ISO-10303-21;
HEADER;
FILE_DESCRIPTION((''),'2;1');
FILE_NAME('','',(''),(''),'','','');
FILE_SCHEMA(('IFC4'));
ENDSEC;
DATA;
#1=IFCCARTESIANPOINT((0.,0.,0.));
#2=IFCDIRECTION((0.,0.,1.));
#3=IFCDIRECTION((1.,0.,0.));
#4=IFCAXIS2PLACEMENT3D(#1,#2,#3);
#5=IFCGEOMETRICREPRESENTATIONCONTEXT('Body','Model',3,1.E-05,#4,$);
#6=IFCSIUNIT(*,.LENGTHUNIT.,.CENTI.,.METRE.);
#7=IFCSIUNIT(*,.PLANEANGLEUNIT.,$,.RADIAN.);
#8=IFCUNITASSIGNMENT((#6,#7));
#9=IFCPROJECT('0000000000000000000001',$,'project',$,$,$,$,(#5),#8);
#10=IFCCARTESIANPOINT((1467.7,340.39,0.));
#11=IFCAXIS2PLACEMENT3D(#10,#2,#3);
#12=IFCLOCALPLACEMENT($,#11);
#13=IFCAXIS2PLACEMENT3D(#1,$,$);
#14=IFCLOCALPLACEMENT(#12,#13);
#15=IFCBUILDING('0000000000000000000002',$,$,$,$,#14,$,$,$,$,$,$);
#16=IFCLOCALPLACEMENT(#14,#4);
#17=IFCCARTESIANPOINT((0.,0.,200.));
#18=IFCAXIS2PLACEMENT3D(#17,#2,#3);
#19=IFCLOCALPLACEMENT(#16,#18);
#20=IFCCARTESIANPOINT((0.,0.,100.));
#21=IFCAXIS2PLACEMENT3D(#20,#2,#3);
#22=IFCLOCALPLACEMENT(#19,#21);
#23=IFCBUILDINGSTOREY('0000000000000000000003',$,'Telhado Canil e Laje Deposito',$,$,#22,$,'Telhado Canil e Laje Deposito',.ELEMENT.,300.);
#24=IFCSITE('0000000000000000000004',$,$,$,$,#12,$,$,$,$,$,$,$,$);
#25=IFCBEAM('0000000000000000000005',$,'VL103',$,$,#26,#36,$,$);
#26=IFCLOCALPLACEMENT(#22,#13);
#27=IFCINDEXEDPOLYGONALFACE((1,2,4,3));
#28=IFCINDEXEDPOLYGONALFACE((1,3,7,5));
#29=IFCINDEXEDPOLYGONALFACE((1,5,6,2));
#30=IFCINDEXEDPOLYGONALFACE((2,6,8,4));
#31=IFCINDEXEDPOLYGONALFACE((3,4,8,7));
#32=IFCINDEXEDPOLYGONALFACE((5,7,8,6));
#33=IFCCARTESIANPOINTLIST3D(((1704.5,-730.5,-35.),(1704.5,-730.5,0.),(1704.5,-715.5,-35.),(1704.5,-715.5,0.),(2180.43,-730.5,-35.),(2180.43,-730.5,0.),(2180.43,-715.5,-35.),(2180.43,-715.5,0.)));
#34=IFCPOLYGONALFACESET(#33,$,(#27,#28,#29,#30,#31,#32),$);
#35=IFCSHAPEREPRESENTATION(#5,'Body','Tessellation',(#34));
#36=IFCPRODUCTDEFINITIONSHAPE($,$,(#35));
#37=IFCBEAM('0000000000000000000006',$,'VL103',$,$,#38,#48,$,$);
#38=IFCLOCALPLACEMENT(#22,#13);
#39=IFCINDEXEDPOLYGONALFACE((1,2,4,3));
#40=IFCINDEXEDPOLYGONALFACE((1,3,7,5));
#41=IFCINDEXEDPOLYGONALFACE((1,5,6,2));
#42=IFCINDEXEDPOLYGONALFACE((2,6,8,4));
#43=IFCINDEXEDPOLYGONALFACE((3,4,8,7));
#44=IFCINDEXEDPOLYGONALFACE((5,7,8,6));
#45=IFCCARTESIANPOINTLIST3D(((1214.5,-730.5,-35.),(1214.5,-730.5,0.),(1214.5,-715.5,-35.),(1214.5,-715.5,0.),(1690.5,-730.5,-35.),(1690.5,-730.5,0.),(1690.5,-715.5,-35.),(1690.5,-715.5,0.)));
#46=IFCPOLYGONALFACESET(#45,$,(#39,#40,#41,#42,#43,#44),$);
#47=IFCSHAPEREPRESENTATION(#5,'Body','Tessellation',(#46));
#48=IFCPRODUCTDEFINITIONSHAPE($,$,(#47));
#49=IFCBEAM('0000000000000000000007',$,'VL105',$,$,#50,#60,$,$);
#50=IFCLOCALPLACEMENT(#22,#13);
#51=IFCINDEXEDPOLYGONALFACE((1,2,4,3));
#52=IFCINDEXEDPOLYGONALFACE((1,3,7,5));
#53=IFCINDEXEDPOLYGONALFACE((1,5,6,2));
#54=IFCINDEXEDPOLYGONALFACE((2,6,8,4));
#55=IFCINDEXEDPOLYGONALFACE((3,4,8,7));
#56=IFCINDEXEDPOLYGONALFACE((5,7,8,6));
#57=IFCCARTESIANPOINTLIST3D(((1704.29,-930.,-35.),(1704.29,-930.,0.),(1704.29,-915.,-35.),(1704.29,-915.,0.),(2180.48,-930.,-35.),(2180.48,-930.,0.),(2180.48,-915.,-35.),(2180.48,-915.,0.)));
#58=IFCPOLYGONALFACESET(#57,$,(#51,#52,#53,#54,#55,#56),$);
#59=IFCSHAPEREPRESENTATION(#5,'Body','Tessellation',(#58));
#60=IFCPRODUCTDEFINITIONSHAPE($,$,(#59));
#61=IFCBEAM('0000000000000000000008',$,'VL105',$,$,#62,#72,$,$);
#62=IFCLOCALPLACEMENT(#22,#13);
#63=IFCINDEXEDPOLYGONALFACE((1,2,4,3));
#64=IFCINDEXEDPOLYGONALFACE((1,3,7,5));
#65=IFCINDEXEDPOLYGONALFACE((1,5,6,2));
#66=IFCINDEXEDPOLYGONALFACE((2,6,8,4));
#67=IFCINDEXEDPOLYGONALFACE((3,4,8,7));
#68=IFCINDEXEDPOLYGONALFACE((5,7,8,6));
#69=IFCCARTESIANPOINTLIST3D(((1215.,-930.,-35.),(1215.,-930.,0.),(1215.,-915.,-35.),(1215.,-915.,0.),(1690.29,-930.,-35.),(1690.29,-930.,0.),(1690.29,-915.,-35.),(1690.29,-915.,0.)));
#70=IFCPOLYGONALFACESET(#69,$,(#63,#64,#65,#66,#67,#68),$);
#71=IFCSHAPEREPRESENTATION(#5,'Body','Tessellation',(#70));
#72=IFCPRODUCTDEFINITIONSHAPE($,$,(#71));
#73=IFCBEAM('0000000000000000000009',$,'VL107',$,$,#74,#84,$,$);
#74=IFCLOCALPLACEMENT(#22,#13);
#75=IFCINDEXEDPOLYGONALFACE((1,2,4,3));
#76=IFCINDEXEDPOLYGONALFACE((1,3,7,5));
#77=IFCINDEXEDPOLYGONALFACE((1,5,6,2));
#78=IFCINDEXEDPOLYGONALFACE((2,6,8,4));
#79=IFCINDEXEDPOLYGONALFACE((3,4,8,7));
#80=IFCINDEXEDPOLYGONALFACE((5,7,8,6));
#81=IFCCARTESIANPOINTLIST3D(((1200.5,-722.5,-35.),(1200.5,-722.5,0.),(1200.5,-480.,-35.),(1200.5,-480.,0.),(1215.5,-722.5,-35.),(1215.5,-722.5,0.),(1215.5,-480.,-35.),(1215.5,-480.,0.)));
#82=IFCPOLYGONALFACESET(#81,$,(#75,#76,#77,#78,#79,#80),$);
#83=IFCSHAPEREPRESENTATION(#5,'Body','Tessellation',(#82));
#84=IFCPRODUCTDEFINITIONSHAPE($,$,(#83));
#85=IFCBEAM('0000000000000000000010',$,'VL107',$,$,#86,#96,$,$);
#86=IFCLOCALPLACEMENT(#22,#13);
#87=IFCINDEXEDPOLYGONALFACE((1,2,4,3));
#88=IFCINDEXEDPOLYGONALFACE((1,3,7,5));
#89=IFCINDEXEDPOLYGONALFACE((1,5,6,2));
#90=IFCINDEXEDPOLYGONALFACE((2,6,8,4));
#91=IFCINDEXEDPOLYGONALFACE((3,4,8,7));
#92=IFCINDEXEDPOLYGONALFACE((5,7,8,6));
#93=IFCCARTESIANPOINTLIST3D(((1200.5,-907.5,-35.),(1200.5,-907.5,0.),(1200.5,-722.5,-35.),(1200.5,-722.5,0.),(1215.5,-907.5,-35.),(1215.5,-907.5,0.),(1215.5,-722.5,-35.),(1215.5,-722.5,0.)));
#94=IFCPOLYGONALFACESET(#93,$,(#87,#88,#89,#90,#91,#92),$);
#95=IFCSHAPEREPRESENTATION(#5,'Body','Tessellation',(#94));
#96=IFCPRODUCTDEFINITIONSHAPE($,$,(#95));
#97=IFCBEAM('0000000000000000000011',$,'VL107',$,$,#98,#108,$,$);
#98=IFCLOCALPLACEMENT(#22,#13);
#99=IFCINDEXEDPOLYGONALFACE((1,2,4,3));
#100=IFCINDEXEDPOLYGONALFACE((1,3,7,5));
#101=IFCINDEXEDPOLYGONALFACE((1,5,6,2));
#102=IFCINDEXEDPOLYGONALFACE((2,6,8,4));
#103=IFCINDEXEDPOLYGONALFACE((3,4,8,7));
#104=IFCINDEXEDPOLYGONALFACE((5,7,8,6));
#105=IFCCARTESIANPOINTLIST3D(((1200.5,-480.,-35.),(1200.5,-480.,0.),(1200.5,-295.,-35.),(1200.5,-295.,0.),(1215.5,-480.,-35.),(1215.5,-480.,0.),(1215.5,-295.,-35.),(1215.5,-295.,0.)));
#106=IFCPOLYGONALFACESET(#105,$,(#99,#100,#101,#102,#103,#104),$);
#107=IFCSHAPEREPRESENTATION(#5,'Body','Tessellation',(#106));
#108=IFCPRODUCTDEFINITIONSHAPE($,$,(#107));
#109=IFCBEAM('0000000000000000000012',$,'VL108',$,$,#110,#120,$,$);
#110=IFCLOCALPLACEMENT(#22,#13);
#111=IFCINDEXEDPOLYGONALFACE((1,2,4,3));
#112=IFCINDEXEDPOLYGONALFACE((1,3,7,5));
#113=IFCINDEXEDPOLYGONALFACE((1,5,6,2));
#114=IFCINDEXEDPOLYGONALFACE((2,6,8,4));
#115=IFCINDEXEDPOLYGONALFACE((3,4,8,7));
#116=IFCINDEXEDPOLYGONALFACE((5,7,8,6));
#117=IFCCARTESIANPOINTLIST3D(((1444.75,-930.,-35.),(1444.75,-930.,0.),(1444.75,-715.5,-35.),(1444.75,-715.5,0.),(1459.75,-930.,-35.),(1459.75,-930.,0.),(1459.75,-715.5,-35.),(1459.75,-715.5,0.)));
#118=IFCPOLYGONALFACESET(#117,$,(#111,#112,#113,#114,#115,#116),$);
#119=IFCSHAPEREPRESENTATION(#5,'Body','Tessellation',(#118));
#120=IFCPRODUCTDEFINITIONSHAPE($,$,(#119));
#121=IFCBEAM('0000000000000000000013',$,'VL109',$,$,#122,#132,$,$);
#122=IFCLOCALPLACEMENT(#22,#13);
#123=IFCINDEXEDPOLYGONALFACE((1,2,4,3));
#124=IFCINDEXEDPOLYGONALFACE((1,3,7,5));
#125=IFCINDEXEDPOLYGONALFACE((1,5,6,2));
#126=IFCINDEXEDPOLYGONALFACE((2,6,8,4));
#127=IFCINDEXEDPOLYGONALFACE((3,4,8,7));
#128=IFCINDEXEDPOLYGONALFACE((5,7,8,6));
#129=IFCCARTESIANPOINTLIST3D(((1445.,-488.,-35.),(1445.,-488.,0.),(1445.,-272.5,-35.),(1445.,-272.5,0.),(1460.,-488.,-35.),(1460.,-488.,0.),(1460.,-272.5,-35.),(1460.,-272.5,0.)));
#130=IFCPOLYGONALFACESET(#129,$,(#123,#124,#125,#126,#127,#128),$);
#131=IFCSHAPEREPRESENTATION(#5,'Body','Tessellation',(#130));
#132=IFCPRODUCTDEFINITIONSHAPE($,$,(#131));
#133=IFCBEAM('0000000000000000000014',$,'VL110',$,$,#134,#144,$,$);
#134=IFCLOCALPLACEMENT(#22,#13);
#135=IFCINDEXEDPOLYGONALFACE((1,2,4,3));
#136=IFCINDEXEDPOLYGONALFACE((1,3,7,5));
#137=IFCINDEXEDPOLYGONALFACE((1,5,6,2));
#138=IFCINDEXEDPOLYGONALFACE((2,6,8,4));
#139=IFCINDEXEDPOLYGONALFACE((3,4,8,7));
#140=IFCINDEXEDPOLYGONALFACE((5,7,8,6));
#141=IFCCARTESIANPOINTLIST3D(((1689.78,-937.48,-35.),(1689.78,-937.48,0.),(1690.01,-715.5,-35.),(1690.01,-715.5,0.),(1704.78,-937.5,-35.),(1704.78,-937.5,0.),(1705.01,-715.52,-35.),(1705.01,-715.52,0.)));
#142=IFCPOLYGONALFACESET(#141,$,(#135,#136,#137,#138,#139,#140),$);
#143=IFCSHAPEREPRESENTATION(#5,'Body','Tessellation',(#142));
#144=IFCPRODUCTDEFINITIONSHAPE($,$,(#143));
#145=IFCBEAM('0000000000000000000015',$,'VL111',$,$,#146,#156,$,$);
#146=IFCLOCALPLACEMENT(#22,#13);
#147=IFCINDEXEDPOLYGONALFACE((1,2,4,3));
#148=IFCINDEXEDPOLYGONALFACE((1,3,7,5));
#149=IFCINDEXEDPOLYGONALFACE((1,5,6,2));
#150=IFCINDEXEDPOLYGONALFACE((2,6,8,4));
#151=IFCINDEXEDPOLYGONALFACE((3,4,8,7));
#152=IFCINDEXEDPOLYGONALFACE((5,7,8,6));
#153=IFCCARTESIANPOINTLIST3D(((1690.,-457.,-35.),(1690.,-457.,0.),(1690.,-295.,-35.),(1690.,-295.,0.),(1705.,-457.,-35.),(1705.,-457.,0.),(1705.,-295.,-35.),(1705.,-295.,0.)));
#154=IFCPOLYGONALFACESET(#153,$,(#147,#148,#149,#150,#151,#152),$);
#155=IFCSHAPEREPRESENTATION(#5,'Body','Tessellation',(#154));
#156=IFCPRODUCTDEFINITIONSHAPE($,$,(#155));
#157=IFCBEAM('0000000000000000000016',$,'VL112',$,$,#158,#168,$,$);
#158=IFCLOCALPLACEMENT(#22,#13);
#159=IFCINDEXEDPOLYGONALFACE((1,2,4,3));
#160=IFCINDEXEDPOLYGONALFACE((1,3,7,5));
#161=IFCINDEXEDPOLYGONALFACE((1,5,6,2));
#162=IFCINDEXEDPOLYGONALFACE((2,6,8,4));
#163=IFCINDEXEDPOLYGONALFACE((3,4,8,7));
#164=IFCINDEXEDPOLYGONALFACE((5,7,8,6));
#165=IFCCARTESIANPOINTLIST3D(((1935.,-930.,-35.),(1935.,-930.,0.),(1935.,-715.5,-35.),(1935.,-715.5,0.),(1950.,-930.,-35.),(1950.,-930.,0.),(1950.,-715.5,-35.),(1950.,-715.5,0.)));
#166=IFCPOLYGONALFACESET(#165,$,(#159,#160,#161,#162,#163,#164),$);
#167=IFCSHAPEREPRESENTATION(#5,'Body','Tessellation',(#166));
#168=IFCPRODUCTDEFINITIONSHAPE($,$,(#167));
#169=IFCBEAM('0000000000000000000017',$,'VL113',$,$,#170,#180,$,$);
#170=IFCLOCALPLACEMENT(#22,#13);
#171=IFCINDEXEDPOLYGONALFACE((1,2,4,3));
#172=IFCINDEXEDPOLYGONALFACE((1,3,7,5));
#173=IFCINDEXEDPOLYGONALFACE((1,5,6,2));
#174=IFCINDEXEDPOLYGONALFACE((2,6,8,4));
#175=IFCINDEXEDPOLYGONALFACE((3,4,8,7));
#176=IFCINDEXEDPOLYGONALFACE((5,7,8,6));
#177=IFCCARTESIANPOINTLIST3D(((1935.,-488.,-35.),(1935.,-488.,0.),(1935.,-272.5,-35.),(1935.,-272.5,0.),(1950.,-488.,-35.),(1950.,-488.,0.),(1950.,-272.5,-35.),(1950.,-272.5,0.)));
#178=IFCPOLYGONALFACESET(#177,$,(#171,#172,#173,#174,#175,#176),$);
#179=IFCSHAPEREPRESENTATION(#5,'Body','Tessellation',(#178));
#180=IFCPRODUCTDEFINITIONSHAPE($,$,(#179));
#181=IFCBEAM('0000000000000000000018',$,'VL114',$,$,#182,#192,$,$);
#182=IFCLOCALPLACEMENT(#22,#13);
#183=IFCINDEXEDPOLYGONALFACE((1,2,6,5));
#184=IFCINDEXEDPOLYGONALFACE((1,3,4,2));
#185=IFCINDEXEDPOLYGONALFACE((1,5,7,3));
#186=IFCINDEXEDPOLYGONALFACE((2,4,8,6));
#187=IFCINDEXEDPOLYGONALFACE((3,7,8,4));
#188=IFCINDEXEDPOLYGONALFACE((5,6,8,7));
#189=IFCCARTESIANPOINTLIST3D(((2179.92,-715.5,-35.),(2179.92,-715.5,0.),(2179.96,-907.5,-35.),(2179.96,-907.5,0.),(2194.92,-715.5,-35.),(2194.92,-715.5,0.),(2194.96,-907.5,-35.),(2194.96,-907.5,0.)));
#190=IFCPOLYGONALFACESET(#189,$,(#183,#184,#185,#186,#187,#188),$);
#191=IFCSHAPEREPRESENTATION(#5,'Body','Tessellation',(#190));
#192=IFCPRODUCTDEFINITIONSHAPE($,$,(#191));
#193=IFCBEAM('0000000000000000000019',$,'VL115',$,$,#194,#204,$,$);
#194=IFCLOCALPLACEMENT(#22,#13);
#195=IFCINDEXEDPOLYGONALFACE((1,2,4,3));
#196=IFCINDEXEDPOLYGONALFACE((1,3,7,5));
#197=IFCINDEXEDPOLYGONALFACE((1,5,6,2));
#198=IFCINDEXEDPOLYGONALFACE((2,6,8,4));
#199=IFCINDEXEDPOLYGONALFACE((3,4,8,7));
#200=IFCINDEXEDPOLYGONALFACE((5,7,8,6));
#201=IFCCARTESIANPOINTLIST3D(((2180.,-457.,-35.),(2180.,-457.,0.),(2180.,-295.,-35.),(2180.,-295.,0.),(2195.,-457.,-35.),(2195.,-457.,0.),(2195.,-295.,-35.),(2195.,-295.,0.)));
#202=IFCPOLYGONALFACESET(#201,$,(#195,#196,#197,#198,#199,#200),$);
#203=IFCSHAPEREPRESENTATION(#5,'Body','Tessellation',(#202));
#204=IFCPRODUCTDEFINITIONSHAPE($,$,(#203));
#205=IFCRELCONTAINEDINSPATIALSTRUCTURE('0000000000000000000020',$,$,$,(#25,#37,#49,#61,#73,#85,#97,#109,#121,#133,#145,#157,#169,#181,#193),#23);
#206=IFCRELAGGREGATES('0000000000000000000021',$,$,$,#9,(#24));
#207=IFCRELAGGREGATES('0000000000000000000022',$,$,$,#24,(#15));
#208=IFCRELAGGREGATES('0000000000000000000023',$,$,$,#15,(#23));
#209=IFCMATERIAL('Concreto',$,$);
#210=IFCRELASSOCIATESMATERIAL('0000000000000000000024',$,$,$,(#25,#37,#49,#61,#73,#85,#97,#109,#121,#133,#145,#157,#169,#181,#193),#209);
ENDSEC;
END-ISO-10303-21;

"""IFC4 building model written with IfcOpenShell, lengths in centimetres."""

from ifc_helpers import new_model, si_unit, frame, origin, origin_with_axes, origin_2d_with_axis, place, context, project, spatial, rectangle, extrude, material, element, save


model = new_model("IFC4")

# Units and contexts
model_context = context("Model", 3, precision=1e-05, world=origin_with_axes(), identifier="Body")
ifc_project = project(units=[si_unit("LENGTHUNIT", "METRE", prefix="CENTI"), si_unit("PLANEANGLEUNIT", "RADIAN")], contexts=[model_context])

# Site, building, storey
site_placement = place(None, frame((1467.7, 340.39, 0.0), z_axis=(0.0, 0.0, 1.0), x_axis=(1.0, 0.0, 0.0)))
site = spatial("IfcSite", under=ifc_project, at=site_placement)
building_placement = place(site_placement, origin())
building = spatial("IfcBuilding", under=site, at=building_placement)
placement_1 = place(building_placement, origin_with_axes())
placement_2 = place(placement_1, frame((0.0, 0.0, 200.0), z_axis=(0.0, 0.0, 1.0), x_axis=(1.0, 0.0, 0.0)))
storey_placement = place(placement_2, frame((0.0, 0.0, 100.0), z_axis=(0.0, 0.0, 1.0), x_axis=(1.0, 0.0, 0.0)))
storey = spatial("IfcBuildingStorey", under=building, at=storey_placement, Name="Telhado Canil e Laje Deposito", LongName="Telhado Canil e Laje Deposito", CompositionType="ELEMENT", Elevation=300.0)

# Shared definitions
ifc_material = material(Name="Concreto")

# Beams
beam_1_placement = place(storey_placement, frame((1942.46, -723.0, 0.0), z_axis=(0.0, 0.0, 1.0), x_axis=(1.0, 0.0, 0.0)))
element("IfcBeam", 1, at=beam_1_placement, inside=storey, material=ifc_material, Name="VL103", context=model_context, shape_type="SolidModel", body=[
    extrude(rectangle(XDim=15.0, YDim=35.0, at=origin_2d_with_axis()), frame((-237.97, 0.0, -17.5), z_axis=(1.0, 0.0, 0.0), x_axis=(0.0, 1.0, 0.0)), (0.0, 0.0, 1.0), 475.93),
])
beam_2_placement = place(storey_placement, frame((1452.5, -723.0, 0.0), z_axis=(0.0, 0.0, 1.0), x_axis=(1.0, 0.0, 0.0)))
element("IfcBeam", 2, at=beam_2_placement, inside=storey, material=ifc_material, Name="VL103", context=model_context, shape_type="SolidModel", body=[
    extrude(rectangle(XDim=15.0, YDim=35.0, at=origin_2d_with_axis()), frame((-238.0, 0.0, -17.5), z_axis=(1.0, 0.0, 0.0), x_axis=(0.0, 1.0, 0.0)), (0.0, 0.0, 1.0), 476.0),
])
beam_3_placement = place(storey_placement, frame((1942.38, -922.5, 0.0), z_axis=(0.0, 0.0, 1.0), x_axis=(1.0, 0.0, 0.0)))
element("IfcBeam", 3, at=beam_3_placement, inside=storey, material=ifc_material, Name="VL105", context=model_context, shape_type="SolidModel", body=[
    extrude(rectangle(XDim=15.0, YDim=35.0, at=origin_2d_with_axis()), frame((-238.09, 0.0, -17.5), z_axis=(1.0, 0.0, 0.0), x_axis=(0.0, 1.0, 0.0)), (0.0, 0.0, 1.0), 476.19),
])
beam_4_placement = place(storey_placement, frame((1452.64, -922.5, 0.0), z_axis=(0.0, 0.0, 1.0), x_axis=(1.0, 0.0, 0.0)))
element("IfcBeam", 4, at=beam_4_placement, inside=storey, material=ifc_material, Name="VL105", context=model_context, shape_type="SolidModel", body=[
    extrude(rectangle(XDim=15.0, YDim=35.0, at=origin_2d_with_axis()), frame((-237.65, 0.0, -17.5), z_axis=(1.0, 0.0, 0.0), x_axis=(0.0, -1.0, 0.0)), (0.0, 0.0, 1.0), 475.29),
])
beam_5_placement = place(storey_placement, frame((1208.0, -601.25, 0.0), z_axis=(0.0, 0.0, 1.0), x_axis=(1.0, 0.0, 0.0)))
element("IfcBeam", 5, at=beam_5_placement, inside=storey, material=ifc_material, Name="VL107", context=model_context, shape_type="SolidModel", body=[
    extrude(rectangle(XDim=15.0, YDim=35.0, at=origin_2d_with_axis()), frame((0.0, -121.25, -17.5), z_axis=(0.0, 1.0, 0.0), x_axis=(1.0, 0.0, 0.0)), (0.0, 0.0, 1.0), 242.5),
])
for number, where, z_axis, x_axis, name in (
    (6, (1208.0, -815.0, 0.0), (0.0, 0.0, 1.0), (1.0, 0.0, 0.0), "VL107"),
    (7, (1208.0, -387.5, 0.0), (0.0, 0.0, 1.0), (1.0, 0.0, 0.0), "VL107"),
):
    element("IfcBeam", number, at=place(storey_placement, frame(where, z_axis=z_axis, x_axis=x_axis)), inside=storey, material=ifc_material, Name=name, context=model_context, shape_type="SolidModel", body=[
        extrude(rectangle(XDim=15.0, YDim=35.0, at=origin_2d_with_axis()), frame((0.0, -92.5, -17.5), z_axis=(0.0, 1.0, 0.0), x_axis=(1.0, 0.0, 0.0)), (0.0, 0.0, 1.0), 185.0),
    ])
beam_6_placement = place(storey_placement, frame((1452.25, -822.75, 0.0), z_axis=(0.0, 0.0, 1.0), x_axis=(1.0, 0.0, 0.0)))
element("IfcBeam", 8, at=beam_6_placement, inside=storey, material=ifc_material, Name="VL108", context=model_context, shape_type="SolidModel", body=[
    extrude(rectangle(XDim=15.0, YDim=35.0, at=origin_2d_with_axis()), frame((0.0, -107.25, -17.5), z_axis=(0.0, 1.0, 0.0), x_axis=(1.0, 0.0, 0.0)), (0.0, 0.0, 1.0), 214.5),
])
beam_7_placement = place(storey_placement, frame((1452.5, -380.25, 0.0), z_axis=(0.0, 0.0, 1.0), x_axis=(1.0, 0.0, 0.0)))
element("IfcBeam", 9, at=beam_7_placement, inside=storey, material=ifc_material, Name="VL109", context=model_context, shape_type="SolidModel", body=[
    extrude(rectangle(XDim=15.0, YDim=35.0, at=origin_2d_with_axis()), frame((0.0, -107.75, -17.5), z_axis=(0.0, 1.0, 0.0), x_axis=(1.0, 0.0, 0.0)), (0.0, 0.0, 1.0), 215.5),
])
beam_8_placement = place(storey_placement, frame((1697.39, -826.5, 0.0), z_axis=(0.0, 0.0, 1.0), x_axis=(1.0, 0.0, 0.0)))
element("IfcBeam", 10, at=beam_8_placement, inside=storey, material=ifc_material, Name="VL110", context=model_context, shape_type="SolidModel", body=[
    extrude(rectangle(XDim=15.0, YDim=35.0, at=origin_2d_with_axis()), frame((-0.12, -110.99, -17.5), z_axis=(0.001049, 1.0, 0.0), x_axis=(1.0, -0.001049, 0.0)), (0.0, 0.0, 1.0), 221.98),
])
beam_9_placement = place(storey_placement, frame((1697.5, -376.0, 0.0), z_axis=(0.0, 0.0, 1.0), x_axis=(1.0, 0.0, 0.0)))
element("IfcBeam", 11, at=beam_9_placement, inside=storey, material=ifc_material, Name="VL111", context=model_context, shape_type="SolidModel", body=[
    extrude(rectangle(XDim=15.0, YDim=35.0, at=origin_2d_with_axis()), frame((0.0, -81.0, -17.5), z_axis=(0.0, 1.0, 0.0), x_axis=(1.0, 0.0, 0.0)), (0.0, 0.0, 1.0), 162.0),
])
beam_10_placement = place(storey_placement, frame((1942.5, -822.75, 0.0), z_axis=(0.0, 0.0, 1.0), x_axis=(1.0, 0.0, 0.0)))
element("IfcBeam", 12, at=beam_10_placement, inside=storey, material=ifc_material, Name="VL112", context=model_context, shape_type="SolidModel", body=[
    extrude(rectangle(XDim=15.0, YDim=35.0, at=origin_2d_with_axis()), frame((0.0, -107.25, -17.5), z_axis=(0.0, 1.0, 0.0), x_axis=(1.0, 0.0, 0.0)), (0.0, 0.0, 1.0), 214.5),
])
beam_11_placement = place(storey_placement, frame((1942.5, -380.25, 0.0), z_axis=(0.0, 0.0, 1.0), x_axis=(1.0, 0.0, 0.0)))
element("IfcBeam", 13, at=beam_11_placement, inside=storey, material=ifc_material, Name="VL113", context=model_context, shape_type="SolidModel", body=[
    extrude(rectangle(XDim=15.0, YDim=35.0, at=origin_2d_with_axis()), frame((0.0, -107.75, -17.5), z_axis=(0.0, 1.0, 0.0), x_axis=(1.0, 0.0, 0.0)), (0.0, 0.0, 1.0), 215.5),
])
beam_12_placement = place(storey_placement, frame((2187.44, -811.5, 0.0), z_axis=(0.0, 0.0, 1.0), x_axis=(1.0, 0.0, 0.0)))
element("IfcBeam", 14, at=beam_12_placement, inside=storey, material=ifc_material, Name="VL114", context=model_context, shape_type="SolidModel", body=[
    extrude(rectangle(XDim=15.0, YDim=35.0, at=origin_2d_with_axis()), frame((0.02, -96.0, -17.5), z_axis=(-0.000185, 1.0, 0.0), x_axis=(1.0, 0.000185, 0.0)), (0.0, 0.0, 1.0), 192.0),
])
beam_13_placement = place(storey_placement, frame((2187.5, -376.0, 0.0), z_axis=(0.0, 0.0, 1.0), x_axis=(1.0, 0.0, 0.0)))
element("IfcBeam", 15, at=beam_13_placement, inside=storey, material=ifc_material, Name="VL115", context=model_context, shape_type="SolidModel", body=[
    extrude(rectangle(XDim=15.0, YDim=35.0, at=origin_2d_with_axis()), frame((0.0, -81.0, -17.5), z_axis=(0.0, 1.0, 0.0), x_axis=(1.0, 0.0, 0.0)), (0.0, 0.0, 1.0), 162.0),
])

save(model, "model.ifc")
